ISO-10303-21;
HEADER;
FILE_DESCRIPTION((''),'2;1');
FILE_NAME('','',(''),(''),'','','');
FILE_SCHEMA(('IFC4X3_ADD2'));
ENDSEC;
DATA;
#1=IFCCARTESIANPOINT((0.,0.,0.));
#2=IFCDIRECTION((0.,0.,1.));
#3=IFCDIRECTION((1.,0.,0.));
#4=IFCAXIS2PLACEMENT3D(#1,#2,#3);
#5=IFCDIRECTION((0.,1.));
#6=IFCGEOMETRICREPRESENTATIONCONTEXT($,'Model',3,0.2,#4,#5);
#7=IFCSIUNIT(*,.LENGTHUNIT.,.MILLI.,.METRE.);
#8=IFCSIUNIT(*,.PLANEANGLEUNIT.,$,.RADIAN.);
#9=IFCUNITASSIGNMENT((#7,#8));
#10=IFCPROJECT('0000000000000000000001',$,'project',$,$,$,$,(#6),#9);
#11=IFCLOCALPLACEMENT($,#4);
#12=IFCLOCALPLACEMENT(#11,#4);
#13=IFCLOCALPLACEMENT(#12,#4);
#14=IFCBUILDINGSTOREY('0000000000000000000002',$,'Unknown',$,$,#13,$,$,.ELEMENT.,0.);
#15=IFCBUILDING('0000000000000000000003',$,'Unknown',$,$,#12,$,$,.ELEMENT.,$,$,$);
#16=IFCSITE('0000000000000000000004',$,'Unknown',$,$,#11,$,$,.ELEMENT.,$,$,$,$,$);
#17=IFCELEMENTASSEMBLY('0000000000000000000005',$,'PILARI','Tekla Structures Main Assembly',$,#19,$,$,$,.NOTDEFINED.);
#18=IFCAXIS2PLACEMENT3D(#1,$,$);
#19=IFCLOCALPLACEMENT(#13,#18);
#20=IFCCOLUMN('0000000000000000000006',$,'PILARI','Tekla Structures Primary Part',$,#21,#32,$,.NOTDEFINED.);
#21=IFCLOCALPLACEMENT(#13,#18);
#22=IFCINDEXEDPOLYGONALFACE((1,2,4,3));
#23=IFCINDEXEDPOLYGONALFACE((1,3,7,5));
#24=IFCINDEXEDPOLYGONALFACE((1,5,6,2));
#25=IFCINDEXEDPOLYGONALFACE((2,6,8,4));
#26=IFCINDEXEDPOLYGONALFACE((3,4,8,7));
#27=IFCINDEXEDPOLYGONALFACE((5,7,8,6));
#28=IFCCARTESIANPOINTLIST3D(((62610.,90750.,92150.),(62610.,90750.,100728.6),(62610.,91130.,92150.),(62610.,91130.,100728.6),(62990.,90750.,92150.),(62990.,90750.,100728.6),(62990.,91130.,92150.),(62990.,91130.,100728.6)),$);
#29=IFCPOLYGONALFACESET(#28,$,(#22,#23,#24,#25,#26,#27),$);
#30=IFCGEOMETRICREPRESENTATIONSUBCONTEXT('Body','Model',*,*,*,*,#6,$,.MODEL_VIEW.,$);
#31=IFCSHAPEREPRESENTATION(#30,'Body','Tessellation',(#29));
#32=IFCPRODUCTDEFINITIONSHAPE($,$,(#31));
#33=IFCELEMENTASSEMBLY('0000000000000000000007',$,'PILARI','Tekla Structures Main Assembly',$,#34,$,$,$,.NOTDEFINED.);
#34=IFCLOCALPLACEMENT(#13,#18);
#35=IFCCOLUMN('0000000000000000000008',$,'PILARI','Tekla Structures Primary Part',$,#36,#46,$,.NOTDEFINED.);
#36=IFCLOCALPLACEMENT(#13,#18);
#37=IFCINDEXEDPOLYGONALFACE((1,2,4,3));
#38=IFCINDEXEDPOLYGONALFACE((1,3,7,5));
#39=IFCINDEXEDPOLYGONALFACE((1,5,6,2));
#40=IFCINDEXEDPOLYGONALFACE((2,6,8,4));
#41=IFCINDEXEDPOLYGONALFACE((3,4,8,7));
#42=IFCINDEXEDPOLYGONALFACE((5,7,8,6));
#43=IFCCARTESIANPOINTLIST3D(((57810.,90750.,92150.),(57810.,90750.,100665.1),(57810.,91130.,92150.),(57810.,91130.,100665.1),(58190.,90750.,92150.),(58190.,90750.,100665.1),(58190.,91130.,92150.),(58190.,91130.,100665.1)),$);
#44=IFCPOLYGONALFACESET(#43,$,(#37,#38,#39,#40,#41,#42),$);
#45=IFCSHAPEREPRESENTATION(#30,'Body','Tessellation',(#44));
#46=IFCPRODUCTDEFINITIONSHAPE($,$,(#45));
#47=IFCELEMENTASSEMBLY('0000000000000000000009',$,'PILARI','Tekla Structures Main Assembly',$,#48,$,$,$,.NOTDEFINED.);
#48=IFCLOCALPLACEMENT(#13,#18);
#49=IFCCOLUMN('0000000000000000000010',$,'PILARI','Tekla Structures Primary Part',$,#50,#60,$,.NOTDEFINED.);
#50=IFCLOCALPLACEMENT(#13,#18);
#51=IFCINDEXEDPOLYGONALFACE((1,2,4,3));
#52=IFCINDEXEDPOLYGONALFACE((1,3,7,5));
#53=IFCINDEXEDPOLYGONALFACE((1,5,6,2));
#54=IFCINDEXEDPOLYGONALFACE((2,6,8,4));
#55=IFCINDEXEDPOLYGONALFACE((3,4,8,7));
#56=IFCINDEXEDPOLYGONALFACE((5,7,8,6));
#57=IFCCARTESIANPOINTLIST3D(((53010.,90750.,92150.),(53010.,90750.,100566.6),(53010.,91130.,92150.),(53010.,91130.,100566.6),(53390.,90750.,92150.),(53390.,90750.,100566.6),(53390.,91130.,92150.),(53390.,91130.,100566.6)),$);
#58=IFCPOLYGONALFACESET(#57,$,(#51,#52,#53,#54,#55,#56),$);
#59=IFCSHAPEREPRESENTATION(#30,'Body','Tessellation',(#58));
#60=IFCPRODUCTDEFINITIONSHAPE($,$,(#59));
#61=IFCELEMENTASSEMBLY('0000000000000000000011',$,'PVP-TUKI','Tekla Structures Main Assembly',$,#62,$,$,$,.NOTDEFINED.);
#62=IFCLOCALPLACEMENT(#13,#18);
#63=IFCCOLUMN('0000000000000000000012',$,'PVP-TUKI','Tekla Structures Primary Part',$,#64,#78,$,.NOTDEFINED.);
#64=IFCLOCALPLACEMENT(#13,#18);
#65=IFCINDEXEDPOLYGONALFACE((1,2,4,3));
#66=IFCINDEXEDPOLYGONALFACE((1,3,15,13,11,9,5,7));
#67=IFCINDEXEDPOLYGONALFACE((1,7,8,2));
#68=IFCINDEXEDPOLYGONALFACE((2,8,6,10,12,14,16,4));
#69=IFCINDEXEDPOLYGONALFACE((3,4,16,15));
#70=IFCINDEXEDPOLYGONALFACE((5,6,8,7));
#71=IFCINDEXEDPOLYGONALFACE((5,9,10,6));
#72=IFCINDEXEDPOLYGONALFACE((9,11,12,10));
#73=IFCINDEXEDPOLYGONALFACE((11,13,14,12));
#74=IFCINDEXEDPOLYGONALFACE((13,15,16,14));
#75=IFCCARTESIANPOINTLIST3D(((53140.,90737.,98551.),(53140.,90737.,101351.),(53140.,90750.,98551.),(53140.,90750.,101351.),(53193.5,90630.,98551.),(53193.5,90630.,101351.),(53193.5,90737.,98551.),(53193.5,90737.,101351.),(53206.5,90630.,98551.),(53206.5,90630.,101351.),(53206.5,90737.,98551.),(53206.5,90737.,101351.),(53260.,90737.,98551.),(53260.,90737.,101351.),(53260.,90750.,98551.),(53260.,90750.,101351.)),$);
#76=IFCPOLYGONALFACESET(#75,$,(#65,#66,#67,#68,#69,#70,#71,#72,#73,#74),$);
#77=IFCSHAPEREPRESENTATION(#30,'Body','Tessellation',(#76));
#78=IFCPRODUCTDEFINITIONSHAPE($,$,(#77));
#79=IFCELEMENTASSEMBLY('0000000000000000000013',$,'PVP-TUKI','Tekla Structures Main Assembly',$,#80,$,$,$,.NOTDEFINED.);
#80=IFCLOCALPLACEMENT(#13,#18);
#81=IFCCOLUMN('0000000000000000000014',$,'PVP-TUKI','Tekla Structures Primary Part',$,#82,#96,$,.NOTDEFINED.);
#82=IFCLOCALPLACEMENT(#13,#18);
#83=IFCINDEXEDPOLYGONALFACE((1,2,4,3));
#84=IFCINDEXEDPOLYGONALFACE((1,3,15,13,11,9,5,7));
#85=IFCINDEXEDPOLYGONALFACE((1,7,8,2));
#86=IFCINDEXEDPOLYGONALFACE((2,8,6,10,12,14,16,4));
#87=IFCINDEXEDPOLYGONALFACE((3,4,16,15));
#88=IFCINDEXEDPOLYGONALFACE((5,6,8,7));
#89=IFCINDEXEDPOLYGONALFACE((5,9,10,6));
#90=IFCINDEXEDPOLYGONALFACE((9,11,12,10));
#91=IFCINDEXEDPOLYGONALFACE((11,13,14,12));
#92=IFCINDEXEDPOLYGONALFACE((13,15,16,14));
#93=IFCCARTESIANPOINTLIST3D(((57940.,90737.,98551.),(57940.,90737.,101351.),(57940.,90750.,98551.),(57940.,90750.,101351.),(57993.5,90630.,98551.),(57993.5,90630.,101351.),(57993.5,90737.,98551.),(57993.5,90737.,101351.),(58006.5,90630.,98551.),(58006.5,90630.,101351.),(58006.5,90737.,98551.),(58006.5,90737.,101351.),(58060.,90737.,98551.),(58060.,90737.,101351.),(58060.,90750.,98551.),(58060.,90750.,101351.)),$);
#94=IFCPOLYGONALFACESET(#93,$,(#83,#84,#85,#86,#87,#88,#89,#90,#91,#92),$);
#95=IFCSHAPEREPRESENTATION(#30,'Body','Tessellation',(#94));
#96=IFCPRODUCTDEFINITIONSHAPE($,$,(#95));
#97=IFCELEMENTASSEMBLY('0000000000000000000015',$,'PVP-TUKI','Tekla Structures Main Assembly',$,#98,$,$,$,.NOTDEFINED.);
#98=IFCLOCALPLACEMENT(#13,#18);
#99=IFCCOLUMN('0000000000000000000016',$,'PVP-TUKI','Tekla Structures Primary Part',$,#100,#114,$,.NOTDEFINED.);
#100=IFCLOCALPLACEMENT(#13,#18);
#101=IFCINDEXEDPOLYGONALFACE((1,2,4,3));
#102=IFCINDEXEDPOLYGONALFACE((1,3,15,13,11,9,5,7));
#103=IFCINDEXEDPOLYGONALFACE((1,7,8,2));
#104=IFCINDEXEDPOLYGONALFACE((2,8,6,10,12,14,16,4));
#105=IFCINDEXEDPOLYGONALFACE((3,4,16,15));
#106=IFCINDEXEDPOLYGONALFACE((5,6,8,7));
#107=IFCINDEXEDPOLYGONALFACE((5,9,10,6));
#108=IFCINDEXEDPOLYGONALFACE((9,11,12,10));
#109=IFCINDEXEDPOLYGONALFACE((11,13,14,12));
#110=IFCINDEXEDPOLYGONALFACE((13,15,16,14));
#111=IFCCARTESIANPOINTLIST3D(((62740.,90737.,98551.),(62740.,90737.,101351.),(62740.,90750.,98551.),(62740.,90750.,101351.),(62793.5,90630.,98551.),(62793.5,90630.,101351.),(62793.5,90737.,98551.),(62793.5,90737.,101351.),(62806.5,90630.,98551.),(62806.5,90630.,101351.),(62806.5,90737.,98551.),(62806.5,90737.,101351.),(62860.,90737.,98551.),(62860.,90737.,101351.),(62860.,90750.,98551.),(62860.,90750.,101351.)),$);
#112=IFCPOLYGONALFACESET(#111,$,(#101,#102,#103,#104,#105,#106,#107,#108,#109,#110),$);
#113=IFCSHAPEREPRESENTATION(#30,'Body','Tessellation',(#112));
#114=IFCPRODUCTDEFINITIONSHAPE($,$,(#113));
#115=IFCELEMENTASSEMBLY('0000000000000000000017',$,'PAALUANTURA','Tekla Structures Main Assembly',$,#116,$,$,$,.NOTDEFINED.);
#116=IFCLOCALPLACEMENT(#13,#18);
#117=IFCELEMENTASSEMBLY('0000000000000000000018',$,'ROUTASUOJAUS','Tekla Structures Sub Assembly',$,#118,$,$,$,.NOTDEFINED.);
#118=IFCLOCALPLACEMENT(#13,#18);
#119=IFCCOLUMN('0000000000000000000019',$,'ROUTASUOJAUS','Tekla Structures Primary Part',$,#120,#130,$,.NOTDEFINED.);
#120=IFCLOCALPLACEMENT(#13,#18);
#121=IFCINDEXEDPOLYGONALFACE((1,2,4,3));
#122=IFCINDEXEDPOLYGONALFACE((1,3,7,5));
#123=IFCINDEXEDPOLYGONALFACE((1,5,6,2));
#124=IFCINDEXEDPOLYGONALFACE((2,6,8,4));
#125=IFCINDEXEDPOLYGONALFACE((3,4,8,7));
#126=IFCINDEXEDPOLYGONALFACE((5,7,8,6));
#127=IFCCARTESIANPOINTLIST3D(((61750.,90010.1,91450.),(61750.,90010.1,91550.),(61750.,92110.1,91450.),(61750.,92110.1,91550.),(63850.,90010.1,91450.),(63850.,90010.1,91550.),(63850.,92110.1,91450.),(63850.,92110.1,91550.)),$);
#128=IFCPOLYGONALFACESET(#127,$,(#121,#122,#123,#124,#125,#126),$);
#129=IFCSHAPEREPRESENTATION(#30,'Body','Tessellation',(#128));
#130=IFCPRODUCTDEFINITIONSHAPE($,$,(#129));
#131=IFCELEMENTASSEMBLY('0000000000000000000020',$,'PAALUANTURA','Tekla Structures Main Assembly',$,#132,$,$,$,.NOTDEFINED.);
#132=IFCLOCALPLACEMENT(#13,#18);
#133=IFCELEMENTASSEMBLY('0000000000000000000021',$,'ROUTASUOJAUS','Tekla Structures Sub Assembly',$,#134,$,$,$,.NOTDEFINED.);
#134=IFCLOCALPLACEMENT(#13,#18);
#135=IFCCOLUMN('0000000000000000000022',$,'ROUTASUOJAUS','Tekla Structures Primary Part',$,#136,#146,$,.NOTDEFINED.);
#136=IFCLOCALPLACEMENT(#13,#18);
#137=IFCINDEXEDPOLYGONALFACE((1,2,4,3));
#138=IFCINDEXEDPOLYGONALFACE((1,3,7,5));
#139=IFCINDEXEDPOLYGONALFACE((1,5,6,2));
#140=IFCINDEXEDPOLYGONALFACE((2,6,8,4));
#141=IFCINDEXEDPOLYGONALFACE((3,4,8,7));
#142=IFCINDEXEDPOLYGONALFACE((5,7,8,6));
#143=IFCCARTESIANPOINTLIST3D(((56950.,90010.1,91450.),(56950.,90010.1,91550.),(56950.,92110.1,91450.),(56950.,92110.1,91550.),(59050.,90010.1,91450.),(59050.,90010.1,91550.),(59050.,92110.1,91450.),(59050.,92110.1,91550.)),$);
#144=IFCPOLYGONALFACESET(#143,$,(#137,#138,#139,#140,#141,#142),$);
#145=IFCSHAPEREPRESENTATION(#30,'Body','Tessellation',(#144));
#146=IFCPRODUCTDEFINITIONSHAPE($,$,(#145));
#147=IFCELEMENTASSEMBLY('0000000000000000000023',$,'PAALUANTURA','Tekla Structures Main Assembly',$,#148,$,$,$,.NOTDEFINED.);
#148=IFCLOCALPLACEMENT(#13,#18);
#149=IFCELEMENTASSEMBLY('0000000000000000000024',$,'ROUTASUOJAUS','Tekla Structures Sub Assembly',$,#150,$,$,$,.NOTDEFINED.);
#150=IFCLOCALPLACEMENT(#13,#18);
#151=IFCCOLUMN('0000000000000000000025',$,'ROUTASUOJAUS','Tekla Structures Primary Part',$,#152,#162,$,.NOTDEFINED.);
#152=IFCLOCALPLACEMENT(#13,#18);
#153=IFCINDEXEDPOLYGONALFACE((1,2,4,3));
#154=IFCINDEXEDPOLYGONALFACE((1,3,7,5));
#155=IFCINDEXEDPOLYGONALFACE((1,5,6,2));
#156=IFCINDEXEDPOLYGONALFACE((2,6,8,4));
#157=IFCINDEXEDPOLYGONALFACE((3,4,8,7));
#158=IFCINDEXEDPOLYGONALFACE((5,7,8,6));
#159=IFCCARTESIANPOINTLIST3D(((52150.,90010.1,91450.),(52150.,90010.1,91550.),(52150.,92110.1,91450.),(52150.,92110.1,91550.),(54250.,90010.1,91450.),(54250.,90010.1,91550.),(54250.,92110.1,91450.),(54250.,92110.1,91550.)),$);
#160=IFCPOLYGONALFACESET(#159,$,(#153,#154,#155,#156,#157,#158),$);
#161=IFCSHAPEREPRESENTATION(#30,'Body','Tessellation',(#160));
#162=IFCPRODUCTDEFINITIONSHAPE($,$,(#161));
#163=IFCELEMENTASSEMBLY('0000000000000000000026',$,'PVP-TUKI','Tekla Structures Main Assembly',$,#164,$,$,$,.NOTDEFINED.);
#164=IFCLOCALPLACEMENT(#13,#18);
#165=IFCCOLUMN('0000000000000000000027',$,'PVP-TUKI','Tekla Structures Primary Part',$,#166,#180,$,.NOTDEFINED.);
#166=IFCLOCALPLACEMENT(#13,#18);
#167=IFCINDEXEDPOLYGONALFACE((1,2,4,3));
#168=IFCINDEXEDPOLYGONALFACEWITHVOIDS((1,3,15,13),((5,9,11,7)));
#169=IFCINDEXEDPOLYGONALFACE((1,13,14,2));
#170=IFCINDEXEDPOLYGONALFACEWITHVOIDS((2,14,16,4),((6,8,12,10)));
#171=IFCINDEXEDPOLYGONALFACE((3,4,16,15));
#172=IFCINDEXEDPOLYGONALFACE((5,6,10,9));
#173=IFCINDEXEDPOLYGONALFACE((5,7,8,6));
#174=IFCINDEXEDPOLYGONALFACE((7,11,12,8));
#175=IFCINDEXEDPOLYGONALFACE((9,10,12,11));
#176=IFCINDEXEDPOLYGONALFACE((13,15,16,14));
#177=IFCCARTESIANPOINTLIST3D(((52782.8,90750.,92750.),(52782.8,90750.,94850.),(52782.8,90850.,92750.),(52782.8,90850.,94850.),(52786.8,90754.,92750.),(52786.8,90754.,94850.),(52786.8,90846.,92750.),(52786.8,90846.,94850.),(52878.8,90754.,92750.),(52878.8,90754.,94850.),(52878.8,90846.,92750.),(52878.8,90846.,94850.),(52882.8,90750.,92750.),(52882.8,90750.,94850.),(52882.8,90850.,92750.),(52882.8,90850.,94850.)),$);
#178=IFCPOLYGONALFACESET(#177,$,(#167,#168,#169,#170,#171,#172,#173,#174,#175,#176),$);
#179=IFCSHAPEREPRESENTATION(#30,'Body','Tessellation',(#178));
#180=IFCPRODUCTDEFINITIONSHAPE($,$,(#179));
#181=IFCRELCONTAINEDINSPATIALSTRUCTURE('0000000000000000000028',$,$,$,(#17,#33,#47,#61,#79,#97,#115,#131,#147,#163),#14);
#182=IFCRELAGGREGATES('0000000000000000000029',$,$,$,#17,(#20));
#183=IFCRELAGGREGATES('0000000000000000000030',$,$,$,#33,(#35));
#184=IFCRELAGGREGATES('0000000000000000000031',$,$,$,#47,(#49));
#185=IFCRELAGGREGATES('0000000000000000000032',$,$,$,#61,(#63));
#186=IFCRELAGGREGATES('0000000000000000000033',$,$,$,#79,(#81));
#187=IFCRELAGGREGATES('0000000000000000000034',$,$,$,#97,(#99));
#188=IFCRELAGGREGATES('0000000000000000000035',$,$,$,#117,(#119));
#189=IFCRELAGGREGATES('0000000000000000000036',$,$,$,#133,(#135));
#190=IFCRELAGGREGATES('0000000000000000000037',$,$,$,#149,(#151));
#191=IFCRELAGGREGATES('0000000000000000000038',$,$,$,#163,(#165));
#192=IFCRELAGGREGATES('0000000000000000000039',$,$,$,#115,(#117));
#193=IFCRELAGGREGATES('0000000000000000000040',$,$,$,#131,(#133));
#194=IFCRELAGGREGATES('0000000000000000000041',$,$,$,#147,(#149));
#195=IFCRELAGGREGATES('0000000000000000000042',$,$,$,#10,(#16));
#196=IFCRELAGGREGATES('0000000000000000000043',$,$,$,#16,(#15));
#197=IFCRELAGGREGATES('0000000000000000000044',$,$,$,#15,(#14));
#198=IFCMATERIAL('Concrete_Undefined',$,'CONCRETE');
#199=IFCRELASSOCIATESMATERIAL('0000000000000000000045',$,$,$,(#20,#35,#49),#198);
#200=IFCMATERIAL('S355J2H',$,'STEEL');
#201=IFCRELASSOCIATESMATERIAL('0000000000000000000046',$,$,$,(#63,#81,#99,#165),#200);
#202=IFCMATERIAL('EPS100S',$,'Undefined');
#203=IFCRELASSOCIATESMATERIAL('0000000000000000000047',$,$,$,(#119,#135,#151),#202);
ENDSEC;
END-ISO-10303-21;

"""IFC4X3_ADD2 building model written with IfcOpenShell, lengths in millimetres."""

from ifc_helpers import new_model, si_unit, direction, frame, origin_with_axes, place, context, subcontext, project, spatial, line, indexed_curve, outline, extrude, material, element, aggregate, save


model = new_model("IFC4X3_ADD2")

# Units and contexts
model_context = context("Model", 3, precision=0.2, world=origin_with_axes(), true_north=direction((0.0, 1.0)))
body_context = subcontext(model_context, "Body", "Model", "MODEL_VIEW")
ifc_project = project(units=[si_unit("LENGTHUNIT", "METRE", prefix="MILLI"), si_unit("PLANEANGLEUNIT", "RADIAN")], contexts=[model_context])

# Site, building, storey
site_placement = place(None, origin_with_axes())
site = spatial("IfcSite", under=ifc_project, at=site_placement, Name="Unknown", CompositionType="ELEMENT")
building_placement = place(site_placement, origin_with_axes())
building = spatial("IfcBuilding", under=site, at=building_placement, Name="Unknown", CompositionType="ELEMENT")
storey_placement = place(building_placement, origin_with_axes())
storey = spatial("IfcBuildingStorey", under=building, at=storey_placement, Name="Unknown", CompositionType="ELEMENT", Elevation=0.0)

# Element assemblies, columns
assembly_1_placement = place(storey_placement, frame((62800.0, 90940.0, 92150.0), z_axis=(-1.0, 0.0, 0.0), x_axis=(0.0, 0.0, 1.0)))
assembly_1 = element("IfcElementAssembly", 1, at=assembly_1_placement, inside=storey, Name="PILARI", Description="Tekla Structures Main Assembly", PredefinedType="NOTDEFINED")
ifc_material_1 = material(Name="Concrete_Undefined", Category="CONCRETE")
column_1_placement = place(assembly_1_placement, origin_with_axes())
column_1 = element("IfcColumn", 2, at=column_1_placement, material=ifc_material_1, Name="PILARI", Description="Tekla Structures Primary Part", PredefinedType="NOTDEFINED", context=body_context, shape_type="SolidModel", body=[
    extrude(outline(indexed_curve([(-190.0, -190.0), (190.0, -190.0), (190.0, 190.0), (-190.0, 190.0)], segments=[line(1, 2, 3, 4, 1)])), frame((0.0, 0.0, 0.0), z_axis=(-1.0, 0.0, 0.0), x_axis=(0.0, 0.0, 1.0)), (0.0, 0.0, -1.0), 8578.6),
])
aggregate(assembly_1, [column_1])
assembly_2_placement = place(storey_placement, frame((58000.0, 90940.0, 92150.0), z_axis=(-1.0, 0.0, 0.0), x_axis=(0.0, 0.0, 1.0)))
assembly_2 = element("IfcElementAssembly", 3, at=assembly_2_placement, inside=storey, Name="PILARI", Description="Tekla Structures Main Assembly", PredefinedType="NOTDEFINED")
column_2_placement = place(assembly_2_placement, origin_with_axes())
column_2 = element("IfcColumn", 4, at=column_2_placement, material=ifc_material_1, Name="PILARI", Description="Tekla Structures Primary Part", PredefinedType="NOTDEFINED", context=body_context, shape_type="SolidModel", body=[
    extrude(outline(indexed_curve([(-190.0, -190.0), (190.0, -190.0), (190.0, 190.0), (-190.0, 190.0)], segments=[line(1, 2, 3, 4, 1)])), frame((0.0, 0.0, 0.0), z_axis=(-1.0, 0.0, 0.0), x_axis=(0.0, 0.0, 1.0)), (0.0, 0.0, -1.0), 8515.1),
])
aggregate(assembly_2, [column_2])
assembly_3_placement = place(storey_placement, frame((53200.0, 90940.0, 92150.0), z_axis=(-1.0, 0.0, 0.0), x_axis=(0.0, 0.0, 1.0)))
assembly_3 = element("IfcElementAssembly", 5, at=assembly_3_placement, inside=storey, Name="PILARI", Description="Tekla Structures Main Assembly", PredefinedType="NOTDEFINED")
column_3_placement = place(assembly_3_placement, origin_with_axes())
column_3 = element("IfcColumn", 6, at=column_3_placement, material=ifc_material_1, Name="PILARI", Description="Tekla Structures Primary Part", PredefinedType="NOTDEFINED", context=body_context, shape_type="SolidModel", body=[
    extrude(outline(indexed_curve([(-190.0, -190.0), (190.0, -190.0), (190.0, 190.0), (-190.0, 190.0)], segments=[line(1, 2, 3, 4, 1)])), frame((0.0, 0.0, 0.0), z_axis=(-1.0, 0.0, 0.0), x_axis=(0.0, 0.0, 1.0)), (0.0, 0.0, -1.0), 8416.6),
])
aggregate(assembly_3, [column_3])
assembly_4_placement = place(storey_placement, frame((53200.0, 90690.0, 98551.0), z_axis=(-1.0, 0.0, 0.0), x_axis=(0.0, 0.0, 1.0)))
assembly_4 = element("IfcElementAssembly", 7, at=assembly_4_placement, inside=storey, Name="PVP-TUKI", Description="Tekla Structures Main Assembly", PredefinedType="NOTDEFINED")
ifc_material_2 = material(Name="S355J2H", Category="STEEL")
column_4_placement = place(assembly_4_placement, origin_with_axes())
column_4 = element("IfcColumn", 8, at=column_4_placement, material=ifc_material_2, Name="PVP-TUKI", Description="Tekla Structures Primary Part", PredefinedType="NOTDEFINED", context=body_context, shape_type="SolidModel", body=[
    extrude(outline(indexed_curve([(-6.5, -60.0), (6.5, -60.0), (6.5, 47.0), (60.0, 47.0), (60.0, 60.0), (-60.0, 60.0), (-60.0, 47.0), (-6.5, 47.0)], segments=[line(1, 2, 3, 4, 5, 6, 7, 8, 1)])), frame((0.0, 0.0, 0.0), z_axis=(-1.0, 0.0, 0.0), x_axis=(0.0, 0.0, 1.0)), (0.0, 0.0, -1.0), 2800.0),
])
aggregate(assembly_4, [column_4])
assembly_5_placement = place(storey_placement, frame((58000.0, 90690.0, 98551.0), z_axis=(-1.0, 0.0, 0.0), x_axis=(0.0, 0.0, 1.0)))
assembly_5 = element("IfcElementAssembly", 9, at=assembly_5_placement, inside=storey, Name="PVP-TUKI", Description="Tekla Structures Main Assembly", PredefinedType="NOTDEFINED")
column_5_placement = place(assembly_5_placement, origin_with_axes())
column_5 = element("IfcColumn", 10, at=column_5_placement, material=ifc_material_2, Name="PVP-TUKI", Description="Tekla Structures Primary Part", PredefinedType="NOTDEFINED", context=body_context, shape_type="SolidModel", body=[
    extrude(outline(indexed_curve([(-6.5, -60.0), (6.5, -60.0), (6.5, 47.0), (60.0, 47.0), (60.0, 60.0), (-60.0, 60.0), (-60.0, 47.0), (-6.5, 47.0)], segments=[line(1, 2, 3, 4, 5, 6, 7, 8, 1)])), frame((0.0, 0.0, 0.0), z_axis=(-1.0, 0.0, 0.0), x_axis=(0.0, 0.0, 1.0)), (0.0, 0.0, -1.0), 2800.0),
])
aggregate(assembly_5, [column_5])
assembly_6_placement = place(storey_placement, frame((62800.0, 90690.0, 98551.0), z_axis=(-1.0, 0.0, 0.0), x_axis=(0.0, 0.0, 1.0)))
assembly_6 = element("IfcElementAssembly", 11, at=assembly_6_placement, inside=storey, Name="PVP-TUKI", Description="Tekla Structures Main Assembly", PredefinedType="NOTDEFINED")
column_6_placement = place(assembly_6_placement, origin_with_axes())
column_6 = element("IfcColumn", 12, at=column_6_placement, material=ifc_material_2, Name="PVP-TUKI", Description="Tekla Structures Primary Part", PredefinedType="NOTDEFINED", context=body_context, shape_type="SolidModel", body=[
    extrude(outline(indexed_curve([(-6.5, -60.0), (6.5, -60.0), (6.5, 47.0), (60.0, 47.0), (60.0, 60.0), (-60.0, 60.0), (-60.0, 47.0), (-6.5, 47.0)], segments=[line(1, 2, 3, 4, 5, 6, 7, 8, 1)])), frame((0.0, 0.0, 0.0), z_axis=(-1.0, 0.0, 0.0), x_axis=(0.0, 0.0, 1.0)), (0.0, 0.0, -1.0), 2800.0),
])
aggregate(assembly_6, [column_6])

# Element assemblies, columns
assembly_7_placement = place(storey_placement, frame((62800.0, 91060.1, 91550.0), z_axis=(0.0, -1.0, 0.0), x_axis=(0.0, 0.0, 1.0)))
assembly_7 = element("IfcElementAssembly", 13, at=assembly_7_placement, inside=storey, Name="PAALUANTURA", Description="Tekla Structures Main Assembly", PredefinedType="NOTDEFINED")
assembly_8_placement = place(assembly_7_placement, frame((-100.0, 0.0, 0.0), z_axis=(0.0, 0.0, 1.0), x_axis=(1.0, 0.0, 0.0)))
assembly_8 = element("IfcElementAssembly", 14, at=assembly_8_placement, Name="ROUTASUOJAUS", Description="Tekla Structures Sub Assembly", PredefinedType="NOTDEFINED")
ifc_material_3 = material(Name="EPS100S", Category="Undefined")
column_7_placement = place(assembly_8_placement, origin_with_axes())
column_7 = element("IfcColumn", 15, at=column_7_placement, material=ifc_material_3, Name="ROUTASUOJAUS", Description="Tekla Structures Primary Part", PredefinedType="NOTDEFINED", context=body_context, shape_type="SolidModel", body=[
    extrude(outline(indexed_curve([(-1050.0, -1050.0), (1050.0, -1050.0), (1050.0, 1050.0), (-1050.0, 1050.0)], segments=[line(1, 2, 3, 4, 1)])), frame((0.0, 0.0, 0.0), z_axis=(-1.0, 0.0, 0.0), x_axis=(0.0, 0.0, 1.0)), (0.0, 0.0, -1.0), 100.0),
])
aggregate(assembly_8, [column_7])
assembly_9_placement = place(storey_placement, frame((58000.0, 91060.1, 91550.0), z_axis=(0.0, -1.0, 0.0), x_axis=(0.0, 0.0, 1.0)))
assembly_9 = element("IfcElementAssembly", 16, at=assembly_9_placement, inside=storey, Name="PAALUANTURA", Description="Tekla Structures Main Assembly", PredefinedType="NOTDEFINED")
assembly_10_placement = place(assembly_9_placement, frame((-100.0, 0.0, 0.0), z_axis=(0.0, 0.0, 1.0), x_axis=(1.0, 0.0, 0.0)))
assembly_10 = element("IfcElementAssembly", 17, at=assembly_10_placement, Name="ROUTASUOJAUS", Description="Tekla Structures Sub Assembly", PredefinedType="NOTDEFINED")
column_8_placement = place(assembly_10_placement, origin_with_axes())
column_8 = element("IfcColumn", 18, at=column_8_placement, material=ifc_material_3, Name="ROUTASUOJAUS", Description="Tekla Structures Primary Part", PredefinedType="NOTDEFINED", context=body_context, shape_type="SolidModel", body=[
    extrude(outline(indexed_curve([(-1050.0, -1050.0), (1050.0, -1050.0), (1050.0, 1050.0), (-1050.0, 1050.0)], segments=[line(1, 2, 3, 4, 1)])), frame((0.0, 0.0, 0.0), z_axis=(-1.0, 0.0, 0.0), x_axis=(0.0, 0.0, 1.0)), (0.0, 0.0, -1.0), 100.0),
])
aggregate(assembly_10, [column_8])
assembly_11_placement = place(storey_placement, frame((53200.0, 91060.1, 91550.0), z_axis=(0.0, -1.0, 0.0), x_axis=(0.0, 0.0, 1.0)))
assembly_11 = element("IfcElementAssembly", 19, at=assembly_11_placement, inside=storey, Name="PAALUANTURA", Description="Tekla Structures Main Assembly", PredefinedType="NOTDEFINED")
assembly_12_placement = place(assembly_11_placement, frame((-100.0, 0.0, 0.0), z_axis=(0.0, 0.0, 1.0), x_axis=(1.0, 0.0, 0.0)))
assembly_12 = element("IfcElementAssembly", 20, at=assembly_12_placement, Name="ROUTASUOJAUS", Description="Tekla Structures Sub Assembly", PredefinedType="NOTDEFINED")
column_9_placement = place(assembly_12_placement, origin_with_axes())
column_9 = element("IfcColumn", 21, at=column_9_placement, material=ifc_material_3, Name="ROUTASUOJAUS", Description="Tekla Structures Primary Part", PredefinedType="NOTDEFINED", context=body_context, shape_type="SolidModel", body=[
    extrude(outline(indexed_curve([(-1050.0, -1050.0), (1050.0, -1050.0), (1050.0, 1050.0), (-1050.0, 1050.0)], segments=[line(1, 2, 3, 4, 1)])), frame((0.0, 0.0, 0.0), z_axis=(-1.0, 0.0, 0.0), x_axis=(0.0, 0.0, 1.0)), (0.0, 0.0, -1.0), 100.0),
])
aggregate(assembly_12, [column_9])

# Element assembly, column
assembly_13_placement = place(storey_placement, frame((52832.8, 90800.0, 92750.0), z_axis=(-1.0, 0.0, 0.0), x_axis=(0.0, 0.0, 1.0)))
assembly_13 = element("IfcElementAssembly", 22, at=assembly_13_placement, inside=storey, Name="PVP-TUKI", Description="Tekla Structures Main Assembly", PredefinedType="NOTDEFINED")
column_10_placement = place(assembly_13_placement, origin_with_axes())
column_10 = element("IfcColumn", 23, at=column_10_placement, material=ifc_material_2, Name="PVP-TUKI", Description="Tekla Structures Primary Part", PredefinedType="NOTDEFINED", context=body_context, shape_type="SolidModel", body=[
    extrude(outline(indexed_curve([(-50.0, -50.0), (50.0, -50.0), (50.0, 50.0), (-50.0, 50.0)], segments=[line(1, 2, 3, 4, 1)]), holes=[indexed_curve([(-46.0, -46.0), (-46.0, 46.0), (46.0, 46.0), (46.0, -46.0)], segments=[line(1, 2, 3, 4, 1)])]), frame((0.0, 0.0, 0.0), z_axis=(-1.0, 0.0, 0.0), x_axis=(0.0, 0.0, 1.0)), (0.0, 0.0, -1.0), 2100.0),
])
aggregate(assembly_13, [column_10])

aggregate(assembly_7, [assembly_8])
aggregate(assembly_9, [assembly_10])
aggregate(assembly_11, [assembly_12])

save(model, "model.ifc")
